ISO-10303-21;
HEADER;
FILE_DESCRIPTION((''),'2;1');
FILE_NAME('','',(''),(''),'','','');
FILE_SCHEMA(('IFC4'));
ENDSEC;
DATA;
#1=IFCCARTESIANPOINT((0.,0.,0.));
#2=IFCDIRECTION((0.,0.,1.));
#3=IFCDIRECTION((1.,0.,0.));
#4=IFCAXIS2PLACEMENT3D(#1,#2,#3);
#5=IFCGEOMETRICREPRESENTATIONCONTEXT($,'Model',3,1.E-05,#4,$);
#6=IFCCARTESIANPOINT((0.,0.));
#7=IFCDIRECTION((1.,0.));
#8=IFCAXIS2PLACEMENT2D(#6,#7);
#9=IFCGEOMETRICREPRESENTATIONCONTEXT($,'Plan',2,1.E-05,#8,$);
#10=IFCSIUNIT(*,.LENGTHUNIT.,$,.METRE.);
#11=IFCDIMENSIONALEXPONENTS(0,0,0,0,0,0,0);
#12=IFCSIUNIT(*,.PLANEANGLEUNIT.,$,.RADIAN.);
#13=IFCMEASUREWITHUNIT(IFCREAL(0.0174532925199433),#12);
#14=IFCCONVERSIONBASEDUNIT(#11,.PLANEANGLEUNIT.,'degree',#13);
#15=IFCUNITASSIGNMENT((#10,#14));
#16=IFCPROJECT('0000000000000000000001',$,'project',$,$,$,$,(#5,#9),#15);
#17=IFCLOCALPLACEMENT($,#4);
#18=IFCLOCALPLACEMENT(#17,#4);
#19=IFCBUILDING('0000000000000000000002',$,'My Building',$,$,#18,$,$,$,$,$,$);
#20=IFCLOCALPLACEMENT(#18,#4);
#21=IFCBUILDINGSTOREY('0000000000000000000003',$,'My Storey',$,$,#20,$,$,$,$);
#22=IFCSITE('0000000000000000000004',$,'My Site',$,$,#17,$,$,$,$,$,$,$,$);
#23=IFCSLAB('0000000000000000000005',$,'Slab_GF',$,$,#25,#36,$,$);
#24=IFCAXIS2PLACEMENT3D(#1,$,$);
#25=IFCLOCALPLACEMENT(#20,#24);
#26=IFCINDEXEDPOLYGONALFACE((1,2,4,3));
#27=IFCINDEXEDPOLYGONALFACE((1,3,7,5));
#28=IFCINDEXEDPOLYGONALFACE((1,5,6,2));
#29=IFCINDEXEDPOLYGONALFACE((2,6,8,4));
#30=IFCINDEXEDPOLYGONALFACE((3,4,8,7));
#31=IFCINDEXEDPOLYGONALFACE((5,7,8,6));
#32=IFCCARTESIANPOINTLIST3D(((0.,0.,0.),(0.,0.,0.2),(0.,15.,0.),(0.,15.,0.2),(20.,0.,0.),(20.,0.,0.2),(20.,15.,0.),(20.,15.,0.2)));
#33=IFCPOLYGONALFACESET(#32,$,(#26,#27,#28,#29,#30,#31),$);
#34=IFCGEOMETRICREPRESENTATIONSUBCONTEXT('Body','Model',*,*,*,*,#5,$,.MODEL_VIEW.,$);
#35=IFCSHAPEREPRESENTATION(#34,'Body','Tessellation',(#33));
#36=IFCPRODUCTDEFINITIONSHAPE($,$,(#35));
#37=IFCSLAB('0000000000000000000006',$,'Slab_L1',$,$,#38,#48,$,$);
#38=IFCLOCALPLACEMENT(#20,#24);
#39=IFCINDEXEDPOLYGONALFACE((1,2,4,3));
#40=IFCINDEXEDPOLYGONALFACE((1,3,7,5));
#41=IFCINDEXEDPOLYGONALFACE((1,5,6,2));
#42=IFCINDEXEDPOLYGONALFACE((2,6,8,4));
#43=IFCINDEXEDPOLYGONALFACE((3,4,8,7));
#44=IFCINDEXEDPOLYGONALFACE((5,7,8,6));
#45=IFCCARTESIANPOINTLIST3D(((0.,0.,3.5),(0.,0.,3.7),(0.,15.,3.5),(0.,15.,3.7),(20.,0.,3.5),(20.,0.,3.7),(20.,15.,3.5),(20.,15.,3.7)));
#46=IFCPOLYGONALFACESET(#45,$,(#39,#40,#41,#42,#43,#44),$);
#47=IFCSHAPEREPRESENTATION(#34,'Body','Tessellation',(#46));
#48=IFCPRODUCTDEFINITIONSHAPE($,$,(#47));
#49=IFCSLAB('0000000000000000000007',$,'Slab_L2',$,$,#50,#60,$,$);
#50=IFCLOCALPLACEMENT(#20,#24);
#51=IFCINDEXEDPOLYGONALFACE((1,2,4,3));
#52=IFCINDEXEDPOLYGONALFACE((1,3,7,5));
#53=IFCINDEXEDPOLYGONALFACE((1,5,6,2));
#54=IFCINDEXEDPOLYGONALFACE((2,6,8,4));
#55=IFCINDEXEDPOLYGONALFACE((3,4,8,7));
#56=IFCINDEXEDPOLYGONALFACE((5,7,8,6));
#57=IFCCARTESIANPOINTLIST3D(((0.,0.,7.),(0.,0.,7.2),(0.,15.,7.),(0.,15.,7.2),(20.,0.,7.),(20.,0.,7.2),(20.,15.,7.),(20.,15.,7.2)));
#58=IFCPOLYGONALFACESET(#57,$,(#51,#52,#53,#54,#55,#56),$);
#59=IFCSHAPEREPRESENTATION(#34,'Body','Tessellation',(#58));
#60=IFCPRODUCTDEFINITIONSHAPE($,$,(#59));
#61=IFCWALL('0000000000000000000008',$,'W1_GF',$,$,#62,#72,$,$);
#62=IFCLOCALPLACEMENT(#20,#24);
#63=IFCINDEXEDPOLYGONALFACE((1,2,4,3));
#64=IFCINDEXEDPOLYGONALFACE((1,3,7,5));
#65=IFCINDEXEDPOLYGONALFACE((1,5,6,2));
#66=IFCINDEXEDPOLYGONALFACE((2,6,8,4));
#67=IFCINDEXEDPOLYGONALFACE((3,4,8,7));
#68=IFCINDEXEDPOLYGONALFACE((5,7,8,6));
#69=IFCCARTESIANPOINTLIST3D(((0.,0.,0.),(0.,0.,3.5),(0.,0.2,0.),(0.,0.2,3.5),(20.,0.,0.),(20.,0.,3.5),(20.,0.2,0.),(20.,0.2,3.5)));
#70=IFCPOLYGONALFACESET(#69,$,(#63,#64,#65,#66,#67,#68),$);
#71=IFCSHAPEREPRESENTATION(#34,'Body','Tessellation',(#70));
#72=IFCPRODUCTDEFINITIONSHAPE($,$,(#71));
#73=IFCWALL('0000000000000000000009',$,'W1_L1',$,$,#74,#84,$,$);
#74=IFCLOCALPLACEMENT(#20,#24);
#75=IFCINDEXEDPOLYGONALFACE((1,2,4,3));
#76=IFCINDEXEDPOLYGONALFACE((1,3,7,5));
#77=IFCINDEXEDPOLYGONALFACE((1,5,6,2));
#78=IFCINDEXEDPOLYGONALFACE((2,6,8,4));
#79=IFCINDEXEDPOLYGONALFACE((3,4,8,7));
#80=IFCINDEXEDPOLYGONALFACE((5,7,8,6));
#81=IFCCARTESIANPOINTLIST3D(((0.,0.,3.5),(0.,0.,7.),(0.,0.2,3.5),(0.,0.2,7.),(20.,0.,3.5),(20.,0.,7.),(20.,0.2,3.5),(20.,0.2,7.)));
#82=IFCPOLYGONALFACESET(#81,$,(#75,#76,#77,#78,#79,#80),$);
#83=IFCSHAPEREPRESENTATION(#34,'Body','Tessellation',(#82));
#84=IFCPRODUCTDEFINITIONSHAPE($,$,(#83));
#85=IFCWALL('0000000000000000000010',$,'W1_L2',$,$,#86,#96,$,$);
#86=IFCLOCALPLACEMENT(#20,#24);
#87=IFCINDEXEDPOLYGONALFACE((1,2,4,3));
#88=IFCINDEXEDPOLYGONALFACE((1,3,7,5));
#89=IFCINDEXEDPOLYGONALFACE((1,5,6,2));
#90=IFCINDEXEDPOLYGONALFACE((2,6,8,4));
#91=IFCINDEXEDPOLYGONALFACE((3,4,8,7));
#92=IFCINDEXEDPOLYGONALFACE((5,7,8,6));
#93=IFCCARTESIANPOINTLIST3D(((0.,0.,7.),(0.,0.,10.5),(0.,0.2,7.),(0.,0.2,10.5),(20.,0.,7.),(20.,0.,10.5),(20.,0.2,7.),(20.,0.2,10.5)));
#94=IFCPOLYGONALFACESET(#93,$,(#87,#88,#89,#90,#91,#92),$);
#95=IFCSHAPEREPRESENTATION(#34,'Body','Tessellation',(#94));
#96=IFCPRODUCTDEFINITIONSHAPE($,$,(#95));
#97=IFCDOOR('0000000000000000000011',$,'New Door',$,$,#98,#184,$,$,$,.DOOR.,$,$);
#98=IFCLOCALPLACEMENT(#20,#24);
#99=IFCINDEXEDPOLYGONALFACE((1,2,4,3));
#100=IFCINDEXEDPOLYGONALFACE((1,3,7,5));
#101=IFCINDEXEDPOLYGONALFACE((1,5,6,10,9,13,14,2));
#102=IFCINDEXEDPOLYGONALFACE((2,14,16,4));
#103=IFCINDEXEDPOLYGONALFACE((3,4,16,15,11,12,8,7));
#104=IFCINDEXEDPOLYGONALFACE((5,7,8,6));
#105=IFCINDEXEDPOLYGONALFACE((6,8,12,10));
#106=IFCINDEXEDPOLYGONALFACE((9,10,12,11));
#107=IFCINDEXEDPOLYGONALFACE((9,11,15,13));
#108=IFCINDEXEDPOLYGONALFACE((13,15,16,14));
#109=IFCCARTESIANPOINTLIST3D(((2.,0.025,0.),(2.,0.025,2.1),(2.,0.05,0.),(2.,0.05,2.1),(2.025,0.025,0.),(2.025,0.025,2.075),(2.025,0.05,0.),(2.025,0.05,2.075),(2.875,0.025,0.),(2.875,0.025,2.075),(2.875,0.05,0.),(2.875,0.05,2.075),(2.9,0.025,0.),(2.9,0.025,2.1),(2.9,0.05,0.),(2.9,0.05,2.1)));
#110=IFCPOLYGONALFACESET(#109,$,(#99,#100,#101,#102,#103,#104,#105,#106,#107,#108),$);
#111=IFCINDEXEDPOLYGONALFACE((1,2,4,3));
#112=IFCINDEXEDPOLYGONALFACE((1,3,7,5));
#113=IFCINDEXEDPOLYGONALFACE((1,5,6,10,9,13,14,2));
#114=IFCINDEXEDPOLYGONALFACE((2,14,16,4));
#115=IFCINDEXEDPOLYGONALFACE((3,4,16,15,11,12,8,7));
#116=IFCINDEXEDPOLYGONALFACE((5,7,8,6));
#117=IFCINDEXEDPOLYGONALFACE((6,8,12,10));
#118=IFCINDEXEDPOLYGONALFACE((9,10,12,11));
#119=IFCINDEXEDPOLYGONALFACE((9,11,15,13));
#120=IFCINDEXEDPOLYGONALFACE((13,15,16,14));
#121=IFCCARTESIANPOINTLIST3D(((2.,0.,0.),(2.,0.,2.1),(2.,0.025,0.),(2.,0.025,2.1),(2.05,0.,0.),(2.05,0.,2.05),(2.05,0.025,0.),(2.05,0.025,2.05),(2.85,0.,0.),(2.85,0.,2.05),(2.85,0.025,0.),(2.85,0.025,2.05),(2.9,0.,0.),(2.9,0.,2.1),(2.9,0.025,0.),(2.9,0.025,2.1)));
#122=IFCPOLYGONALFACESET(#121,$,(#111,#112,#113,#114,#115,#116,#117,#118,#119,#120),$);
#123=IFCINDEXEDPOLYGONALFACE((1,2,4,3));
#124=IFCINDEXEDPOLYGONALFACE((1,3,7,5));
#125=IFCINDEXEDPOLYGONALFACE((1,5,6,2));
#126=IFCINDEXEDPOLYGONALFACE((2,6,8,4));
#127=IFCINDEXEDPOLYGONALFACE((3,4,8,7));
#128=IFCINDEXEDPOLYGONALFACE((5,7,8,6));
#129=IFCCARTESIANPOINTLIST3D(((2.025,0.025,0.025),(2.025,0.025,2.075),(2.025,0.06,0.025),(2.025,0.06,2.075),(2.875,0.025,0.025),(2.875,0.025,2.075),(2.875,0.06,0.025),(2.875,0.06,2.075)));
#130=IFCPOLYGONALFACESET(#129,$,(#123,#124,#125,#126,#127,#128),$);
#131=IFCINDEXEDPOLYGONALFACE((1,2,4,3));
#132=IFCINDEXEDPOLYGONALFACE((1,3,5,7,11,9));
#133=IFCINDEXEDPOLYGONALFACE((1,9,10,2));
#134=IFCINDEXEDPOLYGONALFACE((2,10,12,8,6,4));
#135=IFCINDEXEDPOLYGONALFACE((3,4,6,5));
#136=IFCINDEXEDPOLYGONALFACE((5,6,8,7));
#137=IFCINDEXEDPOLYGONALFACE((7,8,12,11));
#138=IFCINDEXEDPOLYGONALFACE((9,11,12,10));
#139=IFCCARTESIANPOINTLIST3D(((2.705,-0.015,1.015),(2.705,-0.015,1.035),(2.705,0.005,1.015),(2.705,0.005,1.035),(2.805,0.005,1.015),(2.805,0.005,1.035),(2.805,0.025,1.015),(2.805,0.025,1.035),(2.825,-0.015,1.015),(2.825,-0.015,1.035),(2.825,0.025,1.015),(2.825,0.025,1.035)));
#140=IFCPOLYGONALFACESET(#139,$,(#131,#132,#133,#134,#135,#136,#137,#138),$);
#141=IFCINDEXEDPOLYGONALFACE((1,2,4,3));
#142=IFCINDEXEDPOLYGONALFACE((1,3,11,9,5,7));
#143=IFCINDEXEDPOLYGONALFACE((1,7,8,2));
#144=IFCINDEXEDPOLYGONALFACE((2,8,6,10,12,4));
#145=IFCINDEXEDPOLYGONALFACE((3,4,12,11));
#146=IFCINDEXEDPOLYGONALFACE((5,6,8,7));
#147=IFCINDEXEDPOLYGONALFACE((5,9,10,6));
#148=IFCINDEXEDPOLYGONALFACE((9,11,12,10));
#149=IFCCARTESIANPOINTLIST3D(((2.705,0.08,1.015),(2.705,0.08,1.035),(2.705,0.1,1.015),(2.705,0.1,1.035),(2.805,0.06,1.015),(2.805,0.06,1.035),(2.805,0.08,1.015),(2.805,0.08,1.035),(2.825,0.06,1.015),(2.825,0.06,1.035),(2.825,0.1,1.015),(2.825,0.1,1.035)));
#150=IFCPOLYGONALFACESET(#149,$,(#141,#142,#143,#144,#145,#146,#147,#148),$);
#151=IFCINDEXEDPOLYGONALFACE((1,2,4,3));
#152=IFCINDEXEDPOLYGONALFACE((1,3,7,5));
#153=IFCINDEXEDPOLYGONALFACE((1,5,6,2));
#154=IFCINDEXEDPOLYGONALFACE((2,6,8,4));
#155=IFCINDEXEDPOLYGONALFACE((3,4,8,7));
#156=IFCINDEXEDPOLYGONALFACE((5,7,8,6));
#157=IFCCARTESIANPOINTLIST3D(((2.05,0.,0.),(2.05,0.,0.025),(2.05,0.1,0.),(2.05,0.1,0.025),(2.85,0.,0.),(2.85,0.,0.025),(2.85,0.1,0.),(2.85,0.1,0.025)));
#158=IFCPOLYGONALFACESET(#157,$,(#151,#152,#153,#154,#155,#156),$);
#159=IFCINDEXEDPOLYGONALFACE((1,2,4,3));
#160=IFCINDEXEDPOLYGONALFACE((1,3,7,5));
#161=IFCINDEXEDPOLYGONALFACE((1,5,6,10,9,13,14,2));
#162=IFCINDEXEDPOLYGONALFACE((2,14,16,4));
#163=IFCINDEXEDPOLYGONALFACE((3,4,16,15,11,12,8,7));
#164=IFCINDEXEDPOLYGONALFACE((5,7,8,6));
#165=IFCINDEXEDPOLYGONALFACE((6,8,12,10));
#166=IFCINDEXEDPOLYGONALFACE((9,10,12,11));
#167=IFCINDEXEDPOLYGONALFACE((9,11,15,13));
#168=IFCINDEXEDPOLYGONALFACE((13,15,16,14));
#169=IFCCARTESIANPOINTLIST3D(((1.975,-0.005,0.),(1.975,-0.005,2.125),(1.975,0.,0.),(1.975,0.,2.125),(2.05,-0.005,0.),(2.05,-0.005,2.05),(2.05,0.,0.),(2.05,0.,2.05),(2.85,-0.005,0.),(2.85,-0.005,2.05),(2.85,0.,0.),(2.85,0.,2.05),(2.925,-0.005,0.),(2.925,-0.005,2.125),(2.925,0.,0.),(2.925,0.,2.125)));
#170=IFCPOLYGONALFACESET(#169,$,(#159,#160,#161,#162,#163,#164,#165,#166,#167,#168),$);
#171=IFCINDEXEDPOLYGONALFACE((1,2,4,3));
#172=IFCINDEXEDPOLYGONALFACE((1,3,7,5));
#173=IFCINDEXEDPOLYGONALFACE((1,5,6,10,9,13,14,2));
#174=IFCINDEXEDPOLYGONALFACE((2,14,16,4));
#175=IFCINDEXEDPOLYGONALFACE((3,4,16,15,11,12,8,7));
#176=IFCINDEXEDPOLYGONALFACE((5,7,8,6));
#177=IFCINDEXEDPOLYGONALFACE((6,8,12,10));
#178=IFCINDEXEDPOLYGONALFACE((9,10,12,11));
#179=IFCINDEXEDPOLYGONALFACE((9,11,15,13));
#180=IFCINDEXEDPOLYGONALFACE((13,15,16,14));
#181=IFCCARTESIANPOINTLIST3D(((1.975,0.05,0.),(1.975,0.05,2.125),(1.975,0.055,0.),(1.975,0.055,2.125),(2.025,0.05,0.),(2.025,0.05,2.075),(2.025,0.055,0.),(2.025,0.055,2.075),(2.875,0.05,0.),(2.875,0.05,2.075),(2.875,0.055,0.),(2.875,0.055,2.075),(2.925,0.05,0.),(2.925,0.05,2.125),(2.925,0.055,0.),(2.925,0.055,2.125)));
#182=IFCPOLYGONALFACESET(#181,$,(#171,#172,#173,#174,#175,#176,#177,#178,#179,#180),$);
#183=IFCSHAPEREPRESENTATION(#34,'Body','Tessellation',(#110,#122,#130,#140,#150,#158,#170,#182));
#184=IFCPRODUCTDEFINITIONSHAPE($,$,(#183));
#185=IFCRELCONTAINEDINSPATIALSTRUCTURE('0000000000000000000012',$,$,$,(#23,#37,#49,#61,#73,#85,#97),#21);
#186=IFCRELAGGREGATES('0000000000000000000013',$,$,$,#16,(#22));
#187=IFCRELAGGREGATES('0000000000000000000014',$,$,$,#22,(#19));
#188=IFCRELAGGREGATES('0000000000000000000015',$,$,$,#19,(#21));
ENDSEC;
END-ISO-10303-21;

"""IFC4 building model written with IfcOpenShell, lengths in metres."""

from ifc_helpers import new_model, entity, si_unit, converted_unit, frame, origin_with_axes, origin_2d_with_axis, place, context, subcontext, project, spatial, line, indexed_curve, outline, extrude, element, save


model = new_model("IFC4")

# Units and contexts
model_context = context("Model", 3, precision=1e-05, world=origin_with_axes())
plan_context = context("Plan", 2, precision=1e-05, world=origin_2d_with_axis())
body_context = subcontext(model_context, "Body", "Model", "MODEL_VIEW")
ifc_project = project(units=[si_unit("LENGTHUNIT", "METRE"), converted_unit("PLANEANGLEUNIT", "degree", entity("IfcReal", 0.0174532925199433), si_unit("PLANEANGLEUNIT", "RADIAN"), dimensions=[0, 0, 0, 0, 0, 0, 0])], contexts=[model_context, plan_context])

# Site, building, storey
site_placement = place(None, origin_with_axes())
site = spatial("IfcSite", under=ifc_project, at=site_placement, Name="My Site")
building_placement = place(site_placement, origin_with_axes())
building = spatial("IfcBuilding", under=site, at=building_placement, Name="My Building")
storey_placement = place(building_placement, origin_with_axes())
storey = spatial("IfcBuildingStorey", under=building, at=storey_placement, Name="My Storey")

# Slabs
for number, where, z_axis, x_axis, name in (
    (1, (0.0, 0.0, 0.0), (0.0, 0.0, 1.0), (1.0, 0.0, 0.0), "Slab_GF"),
    (2, (0.0, 0.0, 3.5), (0.0, 0.0, 1.0), (1.0, 0.0, 0.0), "Slab_L1"),
    (3, (0.0, 0.0, 7.0), (0.0, 0.0, 1.0), (1.0, 0.0, 0.0), "Slab_L2"),
):
    element("IfcSlab", number, at=place(storey_placement, frame(where, z_axis=z_axis, x_axis=x_axis)), inside=storey, Name=name, context=body_context, shape_type="SweptSolid", body=[
        extrude(outline(indexed_curve([(0.0, 0.0), (20.0, 0.0), (20.0, 15.0), (0.0, 15.0), (0.0, 0.0)])), None, (0.0, 0.0, 1.0), 0.2),
    ])

# Walls
for number, where, z_axis, x_axis, name in (
    (4, (0.0, 0.0, 0.0), (0.0, 0.0, 1.0), (1.0, 0.0, 0.0), "W1_GF"),
    (5, (0.0, 0.0, 3.5), (0.0, 0.0, 1.0), (1.0, 0.0, 0.0), "W1_L1"),
    (6, (0.0, 0.0, 7.0), (0.0, 0.0, 1.0), (1.0, 0.0, 0.0), "W1_L2"),
):
    element("IfcWall", number, at=place(storey_placement, frame(where, z_axis=z_axis, x_axis=x_axis)), inside=storey, Name=name, context=body_context, shape_type="SweptSolid", body=[
        extrude(outline(indexed_curve([(0.0, 0.0), (0.0, 0.2), (20.0, 0.2), (20.0, 0.0), (0.0, 0.0)], self_intersect=False)), origin_with_axes(), (0.0, 0.0, 1.0), 3.5),
    ])

# Door
door_1_placement = place(storey_placement, frame((2.0, 0.0, 0.0), z_axis=(0.0, 0.0, 1.0), x_axis=(1.0, 0.0, 0.0)))
element("IfcDoor", 7, at=door_1_placement, inside=storey, Name="New Door", PredefinedType="DOOR", context=body_context, shape_type="SweptSolid", body=[
    extrude(outline(indexed_curve([(0.0, 0.0), (0.0, 2.1), (0.9, 2.1), (0.9, 0.0), (0.875, 0.0), (0.875, 2.075), (0.025, 2.075), (0.025, 0.0)], segments=[line(1, 2, 3, 4, 5, 6, 7, 8, 1)])), frame((0.0, 0.025, 0.0), z_axis=(0.0, -1.0, 0.0), x_axis=(1.0, 0.0, 0.0)), (0.0, 0.0, -1.0), 0.025),
    extrude(outline(indexed_curve([(0.0, 0.0), (0.0, 2.1), (0.9, 2.1), (0.9, 0.0), (0.85, 0.0), (0.85, 2.05), (0.05, 2.05), (0.05, 0.0)], segments=[line(1, 2, 3, 4, 5, 6, 7, 8, 1)])), frame((0.0, 0.0, 0.0), z_axis=(0.0, -1.0, 0.0), x_axis=(1.0, 0.0, 0.0)), (0.0, 0.0, -1.0), 0.025),
    extrude(outline(indexed_curve([(0.0, 0.0), (0.85, 0.0), (0.85, 0.035), (0.0, 0.035)], segments=[line(1, 2, 3, 4, 1)])), frame((0.025, 0.025, 0.025), z_axis=(0.0, 0.0, 1.0), x_axis=(1.0, 0.0, 0.0)), (0.0, 0.0, 1.0), 2.05),
    extrude(outline(indexed_curve([(0.0, 0.0), (0.0, -0.04), (-0.12, -0.04), (-0.12, -0.02), (-0.02, -0.02), (-0.02, 0.0)], segments=[line(1, 2, 3, 4, 5, 6, 1)])), frame((0.825, 0.025, 1.015), z_axis=(0.0, 0.0, 1.0), x_axis=(1.0, 0.0, 0.0)), (0.0, 0.0, 1.0), 0.02),
    extrude(outline(indexed_curve([(0.0, 0.0), (0.0, 0.04), (-0.12, 0.04), (-0.12, 0.02), (-0.02, 0.02), (-0.02, 0.0)], segments=[line(1, 2, 3, 4, 5, 6, 1)])), frame((0.825, 0.06, 1.015), z_axis=(0.0, 0.0, 1.0), x_axis=(1.0, 0.0, 0.0)), (0.0, 0.0, 1.0), 0.02),
    extrude(outline(indexed_curve([(0.0, 0.0), (0.8, 0.0), (0.8, 0.1), (0.0, 0.1)], segments=[line(1, 2, 3, 4, 1)])), frame((0.05, 0.0, 0.0), z_axis=(0.0, 0.0, 1.0), x_axis=(1.0, 0.0, 0.0)), (0.0, 0.0, 1.0), 0.025),
    extrude(outline(indexed_curve([(0.0, 0.0), (0.0, 2.125), (0.95, 2.125), (0.95, 0.0), (0.875, 0.0), (0.875, 2.05), (0.075, 2.05), (0.075, 0.0)], segments=[line(1, 2, 3, 4, 5, 6, 7, 8, 1)])), frame((-0.025, -0.005, 0.0), z_axis=(0.0, -1.0, 0.0), x_axis=(1.0, 0.0, 0.0)), (0.0, 0.0, -1.0), 0.005),
    extrude(outline(indexed_curve([(0.0, 0.0), (0.0, 2.125), (0.95, 2.125), (0.95, 0.0), (0.9, 0.0), (0.9, 2.075), (0.05, 2.075), (0.05, 0.0)], segments=[line(1, 2, 3, 4, 5, 6, 7, 8, 1)])), frame((-0.025, 0.05, 0.0), z_axis=(0.0, -1.0, 0.0), x_axis=(1.0, 0.0, 0.0)), (0.0, 0.0, -1.0), 0.005),
])

save(model, "model.ifc")
